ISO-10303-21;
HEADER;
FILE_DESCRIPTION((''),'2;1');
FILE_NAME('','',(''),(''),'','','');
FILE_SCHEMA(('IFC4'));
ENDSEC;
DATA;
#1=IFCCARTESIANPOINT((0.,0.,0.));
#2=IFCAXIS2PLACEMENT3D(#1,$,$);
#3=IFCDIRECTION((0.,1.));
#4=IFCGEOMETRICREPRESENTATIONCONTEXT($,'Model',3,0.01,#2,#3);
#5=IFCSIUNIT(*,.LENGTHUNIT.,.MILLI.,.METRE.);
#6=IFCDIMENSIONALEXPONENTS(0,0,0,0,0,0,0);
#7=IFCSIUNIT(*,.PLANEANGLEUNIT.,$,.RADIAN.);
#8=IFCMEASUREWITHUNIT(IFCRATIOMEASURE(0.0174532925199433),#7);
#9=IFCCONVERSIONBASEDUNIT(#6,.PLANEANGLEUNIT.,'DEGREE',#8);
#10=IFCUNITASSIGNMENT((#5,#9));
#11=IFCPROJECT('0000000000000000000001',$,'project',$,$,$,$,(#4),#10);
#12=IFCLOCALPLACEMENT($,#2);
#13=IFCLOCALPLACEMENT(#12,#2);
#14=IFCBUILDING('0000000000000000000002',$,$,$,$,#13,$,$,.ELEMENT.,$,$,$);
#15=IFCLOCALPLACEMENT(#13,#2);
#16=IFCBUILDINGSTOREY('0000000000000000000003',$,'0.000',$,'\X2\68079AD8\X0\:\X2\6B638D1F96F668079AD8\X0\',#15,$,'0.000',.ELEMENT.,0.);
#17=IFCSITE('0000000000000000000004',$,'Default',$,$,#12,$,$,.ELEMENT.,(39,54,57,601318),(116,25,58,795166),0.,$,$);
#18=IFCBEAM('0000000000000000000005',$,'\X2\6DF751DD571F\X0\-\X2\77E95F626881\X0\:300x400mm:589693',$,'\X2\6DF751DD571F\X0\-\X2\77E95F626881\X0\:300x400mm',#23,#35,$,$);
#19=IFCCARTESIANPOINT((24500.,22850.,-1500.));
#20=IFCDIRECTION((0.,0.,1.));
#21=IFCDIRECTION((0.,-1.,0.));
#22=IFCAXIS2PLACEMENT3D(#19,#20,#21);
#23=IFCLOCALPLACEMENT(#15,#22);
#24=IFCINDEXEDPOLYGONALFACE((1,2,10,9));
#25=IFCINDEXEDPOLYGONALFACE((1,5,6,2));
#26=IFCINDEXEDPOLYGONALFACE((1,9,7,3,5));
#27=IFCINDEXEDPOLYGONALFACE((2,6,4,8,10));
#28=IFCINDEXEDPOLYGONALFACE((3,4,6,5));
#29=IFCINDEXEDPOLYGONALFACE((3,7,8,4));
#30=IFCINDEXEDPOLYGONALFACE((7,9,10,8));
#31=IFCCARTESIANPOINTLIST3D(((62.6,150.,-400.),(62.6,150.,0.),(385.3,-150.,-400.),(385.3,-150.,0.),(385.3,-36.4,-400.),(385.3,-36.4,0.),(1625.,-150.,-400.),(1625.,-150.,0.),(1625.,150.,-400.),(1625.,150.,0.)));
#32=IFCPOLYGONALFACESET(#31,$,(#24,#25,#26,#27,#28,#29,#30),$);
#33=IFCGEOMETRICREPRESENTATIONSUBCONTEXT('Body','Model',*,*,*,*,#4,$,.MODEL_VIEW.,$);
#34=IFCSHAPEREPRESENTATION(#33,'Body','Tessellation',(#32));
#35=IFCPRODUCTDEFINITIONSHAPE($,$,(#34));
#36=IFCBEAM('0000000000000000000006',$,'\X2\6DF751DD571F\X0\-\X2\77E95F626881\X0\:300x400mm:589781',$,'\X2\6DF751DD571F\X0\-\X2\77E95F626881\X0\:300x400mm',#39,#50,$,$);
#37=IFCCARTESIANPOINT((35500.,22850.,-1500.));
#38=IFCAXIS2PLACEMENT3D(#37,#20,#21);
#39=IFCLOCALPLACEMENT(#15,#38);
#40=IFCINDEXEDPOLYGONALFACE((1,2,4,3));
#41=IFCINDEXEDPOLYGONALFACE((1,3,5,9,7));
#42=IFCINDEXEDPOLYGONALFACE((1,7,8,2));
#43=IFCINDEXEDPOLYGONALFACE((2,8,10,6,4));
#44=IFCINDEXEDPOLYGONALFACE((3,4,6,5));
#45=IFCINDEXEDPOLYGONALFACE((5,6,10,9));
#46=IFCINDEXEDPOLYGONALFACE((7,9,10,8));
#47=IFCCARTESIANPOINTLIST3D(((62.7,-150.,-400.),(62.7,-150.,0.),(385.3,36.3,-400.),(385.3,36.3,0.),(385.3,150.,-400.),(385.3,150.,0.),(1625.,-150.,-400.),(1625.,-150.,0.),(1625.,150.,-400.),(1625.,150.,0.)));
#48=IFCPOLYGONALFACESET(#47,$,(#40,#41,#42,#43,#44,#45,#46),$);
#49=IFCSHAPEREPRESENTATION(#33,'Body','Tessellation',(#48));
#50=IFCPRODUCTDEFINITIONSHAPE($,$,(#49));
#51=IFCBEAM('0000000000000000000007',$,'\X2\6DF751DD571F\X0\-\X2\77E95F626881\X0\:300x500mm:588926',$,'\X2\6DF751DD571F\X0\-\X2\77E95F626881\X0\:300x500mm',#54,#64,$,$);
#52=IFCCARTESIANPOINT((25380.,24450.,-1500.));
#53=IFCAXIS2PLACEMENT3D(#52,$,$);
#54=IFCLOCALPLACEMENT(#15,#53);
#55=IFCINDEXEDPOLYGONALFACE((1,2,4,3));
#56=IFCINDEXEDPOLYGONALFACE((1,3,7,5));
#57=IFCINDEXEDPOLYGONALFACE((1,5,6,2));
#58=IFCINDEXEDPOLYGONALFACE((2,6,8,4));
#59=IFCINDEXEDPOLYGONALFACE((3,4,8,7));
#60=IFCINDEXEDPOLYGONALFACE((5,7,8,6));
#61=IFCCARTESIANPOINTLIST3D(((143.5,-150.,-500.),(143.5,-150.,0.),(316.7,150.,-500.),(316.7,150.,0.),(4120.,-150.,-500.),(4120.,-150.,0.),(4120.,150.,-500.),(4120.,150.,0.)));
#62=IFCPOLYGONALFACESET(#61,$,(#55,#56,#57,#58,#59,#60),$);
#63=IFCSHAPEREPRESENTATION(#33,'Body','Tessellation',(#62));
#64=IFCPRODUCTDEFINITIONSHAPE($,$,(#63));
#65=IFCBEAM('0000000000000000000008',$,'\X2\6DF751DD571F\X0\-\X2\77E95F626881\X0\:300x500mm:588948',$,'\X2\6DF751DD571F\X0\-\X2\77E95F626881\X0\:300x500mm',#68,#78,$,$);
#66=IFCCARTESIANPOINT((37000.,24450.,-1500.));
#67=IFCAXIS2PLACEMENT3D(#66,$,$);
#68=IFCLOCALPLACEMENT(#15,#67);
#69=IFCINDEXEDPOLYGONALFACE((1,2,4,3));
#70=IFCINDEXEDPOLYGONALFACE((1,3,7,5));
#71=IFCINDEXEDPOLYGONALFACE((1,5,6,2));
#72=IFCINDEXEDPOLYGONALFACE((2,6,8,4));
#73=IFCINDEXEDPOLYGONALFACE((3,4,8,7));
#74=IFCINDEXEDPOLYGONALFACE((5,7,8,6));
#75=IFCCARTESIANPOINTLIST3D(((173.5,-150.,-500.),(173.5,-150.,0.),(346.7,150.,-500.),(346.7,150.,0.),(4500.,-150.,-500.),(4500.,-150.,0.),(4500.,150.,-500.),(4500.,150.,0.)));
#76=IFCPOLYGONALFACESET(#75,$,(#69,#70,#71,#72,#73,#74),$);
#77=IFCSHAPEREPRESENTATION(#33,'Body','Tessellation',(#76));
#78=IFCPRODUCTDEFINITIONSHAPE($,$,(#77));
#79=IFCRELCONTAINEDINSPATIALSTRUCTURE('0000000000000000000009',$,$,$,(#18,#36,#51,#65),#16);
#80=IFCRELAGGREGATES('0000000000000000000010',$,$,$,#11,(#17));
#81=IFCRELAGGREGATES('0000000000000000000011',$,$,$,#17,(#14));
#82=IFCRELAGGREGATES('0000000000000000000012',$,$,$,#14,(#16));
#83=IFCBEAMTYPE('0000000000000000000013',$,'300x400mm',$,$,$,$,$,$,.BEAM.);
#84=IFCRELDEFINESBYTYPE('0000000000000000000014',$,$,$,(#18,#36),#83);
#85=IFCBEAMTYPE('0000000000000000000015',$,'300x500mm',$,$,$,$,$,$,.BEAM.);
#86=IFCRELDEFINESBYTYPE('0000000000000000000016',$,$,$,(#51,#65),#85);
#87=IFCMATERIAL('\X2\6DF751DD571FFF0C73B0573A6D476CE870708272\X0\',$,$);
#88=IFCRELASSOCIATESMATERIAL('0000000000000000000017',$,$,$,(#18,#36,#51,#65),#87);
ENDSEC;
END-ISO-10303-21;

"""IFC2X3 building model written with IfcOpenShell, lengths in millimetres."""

from ifc_helpers import new_model, entity, si_unit, converted_unit, direction, frame, frame_2d, origin, place, context, subcontext, project, spatial, polyline, rectangle, extrude, clip, halfspace, bounded_halfspace, material, type_object, element, save


model = new_model("IFC2X3")

# Units and contexts
model_context = context("Model", 3, precision=0.01, world=origin(), true_north=direction((0.0, 1.0)))
body_context = subcontext(model_context, "Body", "Model", "MODEL_VIEW")
ifc_project = project(units=[si_unit("LENGTHUNIT", "METRE", prefix="MILLI"), converted_unit("PLANEANGLEUNIT", "DEGREE", entity("IfcRatioMeasure", 0.0174532925199433), si_unit("PLANEANGLEUNIT", "RADIAN"), dimensions=[0, 0, 0, 0, 0, 0, 0])], contexts=[model_context])

# Site, building, storey
site_placement = place(None, origin())
site = spatial("IfcSite", under=ifc_project, at=site_placement, Name="Default", CompositionType="ELEMENT", RefLatitude=(39, 54, 57, 601318), RefLongitude=(116, 25, 58, 795166), RefElevation=0.0)
building_placement = place(site_placement, origin())
building = spatial("IfcBuilding", under=site, at=building_placement, CompositionType="ELEMENT")
storey_placement = place(building_placement, origin())
storey = spatial("IfcBuildingStorey", under=building, at=storey_placement, Name="0.000", ObjectType="标高:正负零标高", LongName="0.000", CompositionType="ELEMENT", Elevation=0.0)

# Shared definitions
ifc_material = material(Name="混凝土，现场浇注灰色")

# Beams
beam_type_1 = type_object("IfcBeamType", Name="300x400mm", PredefinedType="BEAM")
beam_1_placement = place(storey_placement, frame((24500.0, 22850.0, -1500.0), z_axis=(0.0, 0.0, 1.0), x_axis=(0.0, -1.0, 0.0)))
element("IfcBeam", 1, at=beam_1_placement, inside=storey, type_object=beam_type_1, material=ifc_material, Name="混凝土-矩形梁:300x400mm:589693", ObjectType="混凝土-矩形梁:300x400mm", context=body_context, shape_type="Clipping", body=[
    clip(clip(extrude(rectangle(XDim=400.0, YDim=300.0, at=frame_2d((0.0, 0.0), x_axis=(1.0, 0.0))), frame((62.6, 0.0, -200.0), z_axis=(1.0, 0.0, 0.0), x_axis=(0.0, 0.0, -1.0)), (0.0, 0.0, 1.0), 1562.4), bounded_halfspace(frame((-2192.6, 1452.4, 0.0), z_axis=(-0.500083, -0.865977, 0.0), x_axis=(0.0, 0.0, -1.0)), False, frame((62.6, 0.0, -200.0), z_axis=(1.0, 0.0, 0.0), x_axis=(0.0, 0.0, -1.0)), polyline([(200.0, -36.4), (-200.0, -36.4), (-200.0, 150.0), (200.0, 150.0), (200.0, -36.4)]))), bounded_halfspace(frame((385.3, -36.4, 0.0), z_axis=(-1.0, 0.0, 0.0), x_axis=(0.0, 0.0, -1.0)), False, frame((62.6, 0.0, -200.0), z_axis=(1.0, 0.0, 0.0), x_axis=(0.0, 0.0, -1.0)), polyline([(-200.0, -36.4), (200.0, -36.4), (200.0, -150.0), (-200.0, -150.0), (-200.0, -36.4)]))),
])
beam_2_placement = place(storey_placement, frame((35500.0, 22850.0, -1500.0), z_axis=(0.0, 0.0, 1.0), x_axis=(0.0, -1.0, 0.0)))
element("IfcBeam", 2, at=beam_2_placement, inside=storey, type_object=beam_type_1, material=ifc_material, Name="混凝土-矩形梁:300x400mm:589781", ObjectType="混凝土-矩形梁:300x400mm", context=body_context, shape_type="Clipping", body=[
    clip(clip(extrude(rectangle(XDim=400.0, YDim=300.0, at=frame_2d((0.0, 0.0), x_axis=(1.0, 0.0))), frame((62.7, 0.0, -200.0), z_axis=(1.0, 0.0, 0.0), x_axis=(0.0, 0.0, -1.0)), (0.0, 0.0, 1.0), 1562.3), bounded_halfspace(frame((385.3, 613.6, 0.0), z_axis=(-1.0, 0.0, 0.0), x_axis=(0.0, 0.0, -1.0)), False, frame((62.7, 0.0, -200.0), z_axis=(1.0, 0.0, 0.0), x_axis=(0.0, 0.0, -1.0)), polyline([(200.0, 36.3), (-200.0, 36.3), (-200.0, 150.0), (200.0, 150.0), (200.0, 36.3)]))), bounded_halfspace(frame((385.3, 36.3, 0.0), z_axis=(-0.500083, 0.865977, 0.0), x_axis=(0.0, 0.0, -1.0)), False, frame((62.7, 0.0, -200.0), z_axis=(1.0, 0.0, 0.0), x_axis=(0.0, 0.0, -1.0)), polyline([(-200.0, 36.3), (200.0, 36.3), (200.0, -150.0), (-200.0, -150.0), (-200.0, 36.3)]))),
])
beam_type_2 = type_object("IfcBeamType", Name="300x500mm", PredefinedType="BEAM")
beam_3_placement = place(storey_placement, frame((25380.0, 24450.0, -1500.0)))
element("IfcBeam", 3, at=beam_3_placement, inside=storey, type_object=beam_type_2, material=ifc_material, Name="混凝土-矩形梁:300x500mm:588926", ObjectType="混凝土-矩形梁:300x500mm", context=body_context, shape_type="Clipping", body=[
    clip(extrude(rectangle(XDim=500.0, YDim=300.0, at=frame_2d((0.0, 0.0), x_axis=(1.0, 0.0))), frame((143.5, 0.0, -250.0), z_axis=(1.0, 0.0, 0.0), x_axis=(0.0, 0.0, -1.0)), (0.0, 0.0, 1.0), 3976.5), halfspace(frame((572.4, 592.6, 0.0), z_axis=(-0.865977, 0.500083, 0.0), x_axis=(0.0, 0.0, -1.0)), False)),
])
beam_4_placement = place(storey_placement, frame((37000.0, 24450.0, -1500.0)))
element("IfcBeam", 4, at=beam_4_placement, inside=storey, type_object=beam_type_2, material=ifc_material, Name="混凝土-矩形梁:300x500mm:588948", ObjectType="混凝土-矩形梁:300x500mm", context=body_context, shape_type="Clipping", body=[
    clip(extrude(rectangle(XDim=500.0, YDim=300.0, at=frame_2d((0.0, 0.0), x_axis=(1.0, 0.0))), frame((173.5, 0.0, -250.0), z_axis=(1.0, 0.0, 0.0), x_axis=(0.0, 0.0, -1.0)), (0.0, 0.0, 1.0), 4326.5), halfspace(frame((602.4, 592.6, 0.0), z_axis=(-0.865977, 0.500083, 0.0), x_axis=(0.0, 0.0, -1.0)), False)),
])

save(model, "model.ifc")
